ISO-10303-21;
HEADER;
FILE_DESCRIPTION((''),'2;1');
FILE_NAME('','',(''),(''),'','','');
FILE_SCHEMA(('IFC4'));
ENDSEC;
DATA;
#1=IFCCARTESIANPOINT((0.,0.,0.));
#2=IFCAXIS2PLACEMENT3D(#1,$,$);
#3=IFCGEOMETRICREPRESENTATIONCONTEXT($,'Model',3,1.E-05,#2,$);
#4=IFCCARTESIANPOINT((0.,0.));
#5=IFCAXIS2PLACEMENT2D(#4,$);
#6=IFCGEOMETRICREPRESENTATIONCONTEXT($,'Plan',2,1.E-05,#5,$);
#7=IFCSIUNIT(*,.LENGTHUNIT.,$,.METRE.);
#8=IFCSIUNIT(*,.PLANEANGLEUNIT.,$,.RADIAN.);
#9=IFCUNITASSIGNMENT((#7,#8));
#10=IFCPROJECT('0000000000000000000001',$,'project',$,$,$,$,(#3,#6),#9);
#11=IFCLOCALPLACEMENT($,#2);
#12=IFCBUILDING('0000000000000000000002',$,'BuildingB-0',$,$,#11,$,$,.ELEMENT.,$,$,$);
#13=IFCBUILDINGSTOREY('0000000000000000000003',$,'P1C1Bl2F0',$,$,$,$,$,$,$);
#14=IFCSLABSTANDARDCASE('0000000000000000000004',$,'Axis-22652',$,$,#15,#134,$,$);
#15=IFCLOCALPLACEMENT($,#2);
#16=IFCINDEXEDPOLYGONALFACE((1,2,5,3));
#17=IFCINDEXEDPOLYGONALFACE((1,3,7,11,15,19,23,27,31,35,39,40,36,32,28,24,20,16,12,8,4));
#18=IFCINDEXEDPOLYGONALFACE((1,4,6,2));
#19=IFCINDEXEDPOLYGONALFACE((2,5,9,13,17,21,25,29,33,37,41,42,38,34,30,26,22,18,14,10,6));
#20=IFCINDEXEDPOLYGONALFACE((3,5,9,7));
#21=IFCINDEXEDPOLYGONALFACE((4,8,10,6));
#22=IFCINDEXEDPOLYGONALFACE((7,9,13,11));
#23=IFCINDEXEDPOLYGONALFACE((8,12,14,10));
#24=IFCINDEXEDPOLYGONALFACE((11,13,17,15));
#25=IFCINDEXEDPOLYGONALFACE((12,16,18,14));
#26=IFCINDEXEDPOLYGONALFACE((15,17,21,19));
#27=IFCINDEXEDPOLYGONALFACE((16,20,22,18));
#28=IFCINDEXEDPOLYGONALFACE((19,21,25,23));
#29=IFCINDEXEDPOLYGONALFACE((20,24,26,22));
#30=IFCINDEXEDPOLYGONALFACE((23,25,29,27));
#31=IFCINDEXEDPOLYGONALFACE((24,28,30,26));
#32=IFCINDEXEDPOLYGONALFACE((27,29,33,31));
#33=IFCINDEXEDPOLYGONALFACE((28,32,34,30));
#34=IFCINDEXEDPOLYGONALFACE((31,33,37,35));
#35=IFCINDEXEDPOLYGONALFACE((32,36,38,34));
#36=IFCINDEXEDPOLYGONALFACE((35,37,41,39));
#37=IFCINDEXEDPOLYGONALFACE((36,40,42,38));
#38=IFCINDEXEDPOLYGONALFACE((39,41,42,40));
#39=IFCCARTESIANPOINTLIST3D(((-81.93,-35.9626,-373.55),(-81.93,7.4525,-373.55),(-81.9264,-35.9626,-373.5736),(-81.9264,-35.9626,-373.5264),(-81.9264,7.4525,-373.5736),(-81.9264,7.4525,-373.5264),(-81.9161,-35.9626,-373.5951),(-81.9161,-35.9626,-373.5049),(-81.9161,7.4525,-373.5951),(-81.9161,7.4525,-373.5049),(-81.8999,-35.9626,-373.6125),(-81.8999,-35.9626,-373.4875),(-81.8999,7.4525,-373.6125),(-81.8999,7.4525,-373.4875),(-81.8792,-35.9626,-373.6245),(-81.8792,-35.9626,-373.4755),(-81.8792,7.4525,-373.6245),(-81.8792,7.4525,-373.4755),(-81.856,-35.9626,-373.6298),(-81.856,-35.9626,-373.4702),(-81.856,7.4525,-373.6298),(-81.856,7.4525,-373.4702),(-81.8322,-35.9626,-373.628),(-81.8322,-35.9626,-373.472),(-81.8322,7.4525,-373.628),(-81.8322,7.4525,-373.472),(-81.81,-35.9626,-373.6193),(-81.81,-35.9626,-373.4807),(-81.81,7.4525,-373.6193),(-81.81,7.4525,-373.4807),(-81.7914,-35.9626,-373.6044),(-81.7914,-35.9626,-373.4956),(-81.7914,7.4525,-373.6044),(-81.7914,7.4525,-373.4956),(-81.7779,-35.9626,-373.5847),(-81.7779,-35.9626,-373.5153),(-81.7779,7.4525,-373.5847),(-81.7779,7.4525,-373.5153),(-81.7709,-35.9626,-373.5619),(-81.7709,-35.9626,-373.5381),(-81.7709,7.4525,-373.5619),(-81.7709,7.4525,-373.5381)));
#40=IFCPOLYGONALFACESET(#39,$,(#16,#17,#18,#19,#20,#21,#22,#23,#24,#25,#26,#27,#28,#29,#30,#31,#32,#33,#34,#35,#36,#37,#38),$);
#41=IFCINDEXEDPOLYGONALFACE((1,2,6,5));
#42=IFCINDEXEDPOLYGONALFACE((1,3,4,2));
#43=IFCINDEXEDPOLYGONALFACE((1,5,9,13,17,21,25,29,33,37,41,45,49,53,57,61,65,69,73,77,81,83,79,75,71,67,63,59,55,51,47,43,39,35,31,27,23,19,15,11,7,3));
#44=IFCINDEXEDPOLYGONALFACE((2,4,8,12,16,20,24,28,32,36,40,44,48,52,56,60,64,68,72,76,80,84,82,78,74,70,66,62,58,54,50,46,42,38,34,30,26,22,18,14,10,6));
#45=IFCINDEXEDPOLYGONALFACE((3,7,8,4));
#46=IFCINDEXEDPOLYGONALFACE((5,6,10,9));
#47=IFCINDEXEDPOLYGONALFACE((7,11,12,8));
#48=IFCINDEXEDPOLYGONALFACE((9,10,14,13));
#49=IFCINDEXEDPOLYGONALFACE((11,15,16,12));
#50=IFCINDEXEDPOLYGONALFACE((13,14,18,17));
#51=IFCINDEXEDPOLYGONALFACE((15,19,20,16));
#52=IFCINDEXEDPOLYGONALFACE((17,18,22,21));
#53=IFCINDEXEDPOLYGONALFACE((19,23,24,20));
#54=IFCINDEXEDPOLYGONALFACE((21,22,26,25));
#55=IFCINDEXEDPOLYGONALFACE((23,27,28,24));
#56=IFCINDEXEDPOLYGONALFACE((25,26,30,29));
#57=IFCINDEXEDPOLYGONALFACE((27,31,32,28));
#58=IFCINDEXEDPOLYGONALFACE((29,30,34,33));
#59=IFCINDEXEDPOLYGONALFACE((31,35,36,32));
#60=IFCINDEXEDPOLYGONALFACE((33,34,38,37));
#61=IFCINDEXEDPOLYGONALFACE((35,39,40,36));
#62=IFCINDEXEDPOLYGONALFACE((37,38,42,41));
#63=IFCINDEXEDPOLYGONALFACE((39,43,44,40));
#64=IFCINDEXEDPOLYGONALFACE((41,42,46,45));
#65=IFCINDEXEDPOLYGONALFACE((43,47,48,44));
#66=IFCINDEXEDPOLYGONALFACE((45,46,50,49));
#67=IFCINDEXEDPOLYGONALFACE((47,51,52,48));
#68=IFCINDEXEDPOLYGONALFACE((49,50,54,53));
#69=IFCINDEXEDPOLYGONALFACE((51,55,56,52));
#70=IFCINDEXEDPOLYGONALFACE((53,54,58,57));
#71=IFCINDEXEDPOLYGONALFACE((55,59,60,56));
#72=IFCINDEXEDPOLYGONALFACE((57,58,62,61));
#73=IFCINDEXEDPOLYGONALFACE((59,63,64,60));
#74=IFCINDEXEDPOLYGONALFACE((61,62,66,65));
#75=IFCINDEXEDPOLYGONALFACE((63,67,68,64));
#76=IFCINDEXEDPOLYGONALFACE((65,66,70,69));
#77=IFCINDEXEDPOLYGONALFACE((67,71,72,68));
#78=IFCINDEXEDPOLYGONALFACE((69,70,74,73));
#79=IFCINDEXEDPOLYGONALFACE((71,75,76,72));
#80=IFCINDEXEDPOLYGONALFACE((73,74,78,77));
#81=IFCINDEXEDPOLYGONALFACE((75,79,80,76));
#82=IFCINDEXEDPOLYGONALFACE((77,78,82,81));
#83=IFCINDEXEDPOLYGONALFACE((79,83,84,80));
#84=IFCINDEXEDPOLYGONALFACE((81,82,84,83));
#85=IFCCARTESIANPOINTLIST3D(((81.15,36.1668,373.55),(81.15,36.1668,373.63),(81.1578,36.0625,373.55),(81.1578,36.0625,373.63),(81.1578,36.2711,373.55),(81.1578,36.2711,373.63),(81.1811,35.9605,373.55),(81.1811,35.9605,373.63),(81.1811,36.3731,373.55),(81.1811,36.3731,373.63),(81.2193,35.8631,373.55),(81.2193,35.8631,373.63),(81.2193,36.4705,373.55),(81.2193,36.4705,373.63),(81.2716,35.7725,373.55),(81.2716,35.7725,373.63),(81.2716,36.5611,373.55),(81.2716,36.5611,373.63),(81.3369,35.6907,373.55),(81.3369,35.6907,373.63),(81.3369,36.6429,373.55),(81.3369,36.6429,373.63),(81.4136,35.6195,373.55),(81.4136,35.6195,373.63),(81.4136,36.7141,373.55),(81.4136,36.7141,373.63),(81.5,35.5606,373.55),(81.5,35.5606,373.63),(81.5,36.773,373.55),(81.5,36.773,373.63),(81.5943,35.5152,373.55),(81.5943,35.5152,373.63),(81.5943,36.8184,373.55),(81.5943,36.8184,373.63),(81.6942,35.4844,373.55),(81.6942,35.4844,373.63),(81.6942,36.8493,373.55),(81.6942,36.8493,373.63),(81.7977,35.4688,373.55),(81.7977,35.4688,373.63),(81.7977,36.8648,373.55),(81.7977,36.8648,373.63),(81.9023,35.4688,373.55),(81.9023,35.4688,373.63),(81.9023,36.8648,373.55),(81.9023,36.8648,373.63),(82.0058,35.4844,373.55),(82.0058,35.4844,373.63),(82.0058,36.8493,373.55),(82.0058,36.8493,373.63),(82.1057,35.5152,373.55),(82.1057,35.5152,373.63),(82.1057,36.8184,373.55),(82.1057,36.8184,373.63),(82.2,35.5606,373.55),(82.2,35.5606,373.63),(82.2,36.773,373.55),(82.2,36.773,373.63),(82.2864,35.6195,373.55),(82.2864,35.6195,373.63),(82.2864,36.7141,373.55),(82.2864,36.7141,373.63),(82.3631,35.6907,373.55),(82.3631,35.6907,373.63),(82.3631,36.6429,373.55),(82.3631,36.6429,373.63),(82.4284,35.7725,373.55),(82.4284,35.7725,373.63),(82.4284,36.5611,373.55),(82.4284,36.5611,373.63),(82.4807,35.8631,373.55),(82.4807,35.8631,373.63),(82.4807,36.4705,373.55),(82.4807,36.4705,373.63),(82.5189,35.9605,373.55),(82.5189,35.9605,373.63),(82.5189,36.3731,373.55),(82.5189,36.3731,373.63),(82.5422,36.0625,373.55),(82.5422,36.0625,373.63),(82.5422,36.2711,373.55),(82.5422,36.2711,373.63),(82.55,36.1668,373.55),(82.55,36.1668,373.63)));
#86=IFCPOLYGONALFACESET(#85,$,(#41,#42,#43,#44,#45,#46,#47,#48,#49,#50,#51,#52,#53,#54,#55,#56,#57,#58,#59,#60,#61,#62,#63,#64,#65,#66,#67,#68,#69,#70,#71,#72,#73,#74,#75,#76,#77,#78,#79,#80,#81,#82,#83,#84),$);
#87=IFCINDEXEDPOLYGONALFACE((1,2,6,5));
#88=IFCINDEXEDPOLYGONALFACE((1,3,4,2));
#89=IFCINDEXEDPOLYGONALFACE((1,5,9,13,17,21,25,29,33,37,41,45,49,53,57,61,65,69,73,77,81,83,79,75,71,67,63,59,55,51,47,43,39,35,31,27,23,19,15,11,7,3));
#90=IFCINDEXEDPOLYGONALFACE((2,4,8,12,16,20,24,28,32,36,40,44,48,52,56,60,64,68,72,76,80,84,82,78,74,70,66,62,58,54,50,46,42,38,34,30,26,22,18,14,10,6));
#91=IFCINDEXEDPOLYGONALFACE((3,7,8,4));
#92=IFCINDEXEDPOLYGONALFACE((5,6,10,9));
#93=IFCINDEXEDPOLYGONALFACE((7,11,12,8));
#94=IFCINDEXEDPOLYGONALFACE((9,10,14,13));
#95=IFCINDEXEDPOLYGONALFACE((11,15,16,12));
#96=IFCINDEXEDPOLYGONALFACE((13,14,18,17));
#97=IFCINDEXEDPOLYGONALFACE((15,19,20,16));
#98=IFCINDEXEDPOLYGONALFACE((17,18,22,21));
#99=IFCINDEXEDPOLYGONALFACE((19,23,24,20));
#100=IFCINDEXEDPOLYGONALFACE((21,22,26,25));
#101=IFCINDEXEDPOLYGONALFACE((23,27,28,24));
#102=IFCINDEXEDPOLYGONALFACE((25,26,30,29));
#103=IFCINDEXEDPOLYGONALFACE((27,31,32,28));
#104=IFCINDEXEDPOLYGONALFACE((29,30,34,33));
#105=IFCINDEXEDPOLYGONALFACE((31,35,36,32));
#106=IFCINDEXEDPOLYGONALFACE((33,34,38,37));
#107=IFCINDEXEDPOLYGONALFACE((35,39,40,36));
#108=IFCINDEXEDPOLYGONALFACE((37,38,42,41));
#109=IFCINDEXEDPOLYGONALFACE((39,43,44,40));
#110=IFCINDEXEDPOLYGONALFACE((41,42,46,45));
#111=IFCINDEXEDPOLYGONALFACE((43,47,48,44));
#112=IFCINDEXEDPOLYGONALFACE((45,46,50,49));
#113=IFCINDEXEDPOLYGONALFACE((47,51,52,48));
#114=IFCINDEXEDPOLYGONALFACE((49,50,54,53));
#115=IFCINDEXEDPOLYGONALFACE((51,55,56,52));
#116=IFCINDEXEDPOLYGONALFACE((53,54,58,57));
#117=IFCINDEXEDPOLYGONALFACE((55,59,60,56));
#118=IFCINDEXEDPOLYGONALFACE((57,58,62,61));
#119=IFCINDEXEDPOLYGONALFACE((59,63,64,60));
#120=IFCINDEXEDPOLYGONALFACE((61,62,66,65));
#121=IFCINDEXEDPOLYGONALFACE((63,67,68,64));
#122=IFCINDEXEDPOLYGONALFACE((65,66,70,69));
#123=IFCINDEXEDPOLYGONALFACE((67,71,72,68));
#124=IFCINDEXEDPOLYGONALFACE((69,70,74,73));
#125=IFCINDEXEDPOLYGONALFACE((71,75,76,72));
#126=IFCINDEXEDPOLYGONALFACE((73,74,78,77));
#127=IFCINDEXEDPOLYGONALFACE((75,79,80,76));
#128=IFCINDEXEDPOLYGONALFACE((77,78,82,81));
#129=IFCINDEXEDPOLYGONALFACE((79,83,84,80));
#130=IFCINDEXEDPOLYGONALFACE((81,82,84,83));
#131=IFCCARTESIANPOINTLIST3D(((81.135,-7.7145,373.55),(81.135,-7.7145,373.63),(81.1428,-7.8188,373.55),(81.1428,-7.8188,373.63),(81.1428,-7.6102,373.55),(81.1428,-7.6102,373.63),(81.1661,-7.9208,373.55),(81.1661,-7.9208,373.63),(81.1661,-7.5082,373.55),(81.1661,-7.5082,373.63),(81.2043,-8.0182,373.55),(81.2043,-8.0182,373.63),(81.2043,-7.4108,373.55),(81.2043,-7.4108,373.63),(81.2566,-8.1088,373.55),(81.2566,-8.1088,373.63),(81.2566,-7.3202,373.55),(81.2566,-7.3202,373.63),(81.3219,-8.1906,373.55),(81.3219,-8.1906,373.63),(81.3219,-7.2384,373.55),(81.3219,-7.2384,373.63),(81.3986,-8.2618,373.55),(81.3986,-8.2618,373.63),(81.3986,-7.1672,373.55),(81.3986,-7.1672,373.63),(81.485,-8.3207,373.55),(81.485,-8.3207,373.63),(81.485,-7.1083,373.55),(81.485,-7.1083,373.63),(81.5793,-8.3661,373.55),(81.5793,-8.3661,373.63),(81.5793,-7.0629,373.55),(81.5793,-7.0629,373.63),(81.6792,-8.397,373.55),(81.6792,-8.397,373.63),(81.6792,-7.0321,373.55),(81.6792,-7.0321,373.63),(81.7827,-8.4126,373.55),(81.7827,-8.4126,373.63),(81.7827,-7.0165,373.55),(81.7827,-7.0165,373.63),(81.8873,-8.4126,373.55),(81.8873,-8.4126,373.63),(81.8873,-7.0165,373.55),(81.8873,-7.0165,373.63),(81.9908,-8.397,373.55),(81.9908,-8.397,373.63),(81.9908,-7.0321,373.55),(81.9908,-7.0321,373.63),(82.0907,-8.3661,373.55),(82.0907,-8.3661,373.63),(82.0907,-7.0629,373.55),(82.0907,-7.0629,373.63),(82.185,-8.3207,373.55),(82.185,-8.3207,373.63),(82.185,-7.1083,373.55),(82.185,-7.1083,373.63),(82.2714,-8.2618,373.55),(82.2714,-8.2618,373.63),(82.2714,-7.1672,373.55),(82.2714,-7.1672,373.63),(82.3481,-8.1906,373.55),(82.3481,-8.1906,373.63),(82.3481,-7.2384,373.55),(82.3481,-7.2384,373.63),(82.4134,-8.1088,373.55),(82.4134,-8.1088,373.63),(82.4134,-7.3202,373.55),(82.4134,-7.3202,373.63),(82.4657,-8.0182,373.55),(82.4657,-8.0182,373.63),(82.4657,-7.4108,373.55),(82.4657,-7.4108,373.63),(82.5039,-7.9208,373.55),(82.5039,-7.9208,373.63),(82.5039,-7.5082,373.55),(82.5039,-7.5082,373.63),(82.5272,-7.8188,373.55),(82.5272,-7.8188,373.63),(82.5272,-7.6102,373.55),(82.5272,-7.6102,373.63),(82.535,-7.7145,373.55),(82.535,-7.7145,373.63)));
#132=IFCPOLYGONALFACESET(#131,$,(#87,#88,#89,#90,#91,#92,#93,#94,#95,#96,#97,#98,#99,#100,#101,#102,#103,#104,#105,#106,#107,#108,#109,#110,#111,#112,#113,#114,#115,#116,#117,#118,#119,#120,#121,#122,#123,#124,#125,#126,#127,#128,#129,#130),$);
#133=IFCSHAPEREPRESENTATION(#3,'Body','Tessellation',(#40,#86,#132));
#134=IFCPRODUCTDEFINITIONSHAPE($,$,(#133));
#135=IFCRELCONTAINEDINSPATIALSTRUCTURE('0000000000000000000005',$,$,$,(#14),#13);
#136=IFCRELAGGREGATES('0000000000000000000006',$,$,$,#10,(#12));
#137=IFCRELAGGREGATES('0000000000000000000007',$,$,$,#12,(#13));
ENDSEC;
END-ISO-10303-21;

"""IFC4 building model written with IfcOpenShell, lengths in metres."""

from ifc_helpers import new_model, entity, si_unit, frame, origin, origin_2d, place, context, project, spatial, circle, extrude, element, save


model = new_model("IFC4")

# Units and contexts
model_context = context("Model", 3, precision=1e-05, world=origin())
plan_context = context("Plan", 2, precision=1e-05, world=origin_2d())
ifc_project = project(units=[si_unit("LENGTHUNIT", "METRE"), si_unit("PLANEANGLEUNIT", "RADIAN")], contexts=[model_context, plan_context])

# Building, storey
building_placement = place(None, origin())
building = spatial("IfcBuilding", under=ifc_project, at=building_placement, Name="BuildingB-0", CompositionType="ELEMENT")
storey = spatial("IfcBuildingStorey", under=building, Name="P1C1Bl2F0")

# Slab
element("IfcSlabStandardCase", 1, inside=storey, Name="Axis-22652", context=model_context, shape_type="AdvancedSweptSolid", body=[
    entity("IfcSurfaceCurveSweptAreaSolid", entity("IfcCircleProfileDef", "AREA", None, None, 0.08), None, entity("IfcPolyline", [entity("IfcCartesianPoint", [81.85, 35.9626, 373.55]), entity("IfcCartesianPoint", [81.85, -7.4525, 373.55])]), None, None, entity("IfcPlane", entity("IfcAxis2Placement3D", entity("IfcCartesianPoint", [81.85, 35.9626, 373.55]), entity("IfcDirection", [0.0, 0.0, 1.0]), entity("IfcDirection", [1.0, 0.0, 0.0])))),
    extrude(circle(Radius=0.7), frame((81.85, 36.1668, 373.55)), (0.0, 0.0, 1.0), 0.08),
    extrude(circle(Radius=0.7), frame((81.835, -7.7145, 373.55)), (0.0, 0.0, 1.0), 0.08),
])

save(model, "model.ifc")
